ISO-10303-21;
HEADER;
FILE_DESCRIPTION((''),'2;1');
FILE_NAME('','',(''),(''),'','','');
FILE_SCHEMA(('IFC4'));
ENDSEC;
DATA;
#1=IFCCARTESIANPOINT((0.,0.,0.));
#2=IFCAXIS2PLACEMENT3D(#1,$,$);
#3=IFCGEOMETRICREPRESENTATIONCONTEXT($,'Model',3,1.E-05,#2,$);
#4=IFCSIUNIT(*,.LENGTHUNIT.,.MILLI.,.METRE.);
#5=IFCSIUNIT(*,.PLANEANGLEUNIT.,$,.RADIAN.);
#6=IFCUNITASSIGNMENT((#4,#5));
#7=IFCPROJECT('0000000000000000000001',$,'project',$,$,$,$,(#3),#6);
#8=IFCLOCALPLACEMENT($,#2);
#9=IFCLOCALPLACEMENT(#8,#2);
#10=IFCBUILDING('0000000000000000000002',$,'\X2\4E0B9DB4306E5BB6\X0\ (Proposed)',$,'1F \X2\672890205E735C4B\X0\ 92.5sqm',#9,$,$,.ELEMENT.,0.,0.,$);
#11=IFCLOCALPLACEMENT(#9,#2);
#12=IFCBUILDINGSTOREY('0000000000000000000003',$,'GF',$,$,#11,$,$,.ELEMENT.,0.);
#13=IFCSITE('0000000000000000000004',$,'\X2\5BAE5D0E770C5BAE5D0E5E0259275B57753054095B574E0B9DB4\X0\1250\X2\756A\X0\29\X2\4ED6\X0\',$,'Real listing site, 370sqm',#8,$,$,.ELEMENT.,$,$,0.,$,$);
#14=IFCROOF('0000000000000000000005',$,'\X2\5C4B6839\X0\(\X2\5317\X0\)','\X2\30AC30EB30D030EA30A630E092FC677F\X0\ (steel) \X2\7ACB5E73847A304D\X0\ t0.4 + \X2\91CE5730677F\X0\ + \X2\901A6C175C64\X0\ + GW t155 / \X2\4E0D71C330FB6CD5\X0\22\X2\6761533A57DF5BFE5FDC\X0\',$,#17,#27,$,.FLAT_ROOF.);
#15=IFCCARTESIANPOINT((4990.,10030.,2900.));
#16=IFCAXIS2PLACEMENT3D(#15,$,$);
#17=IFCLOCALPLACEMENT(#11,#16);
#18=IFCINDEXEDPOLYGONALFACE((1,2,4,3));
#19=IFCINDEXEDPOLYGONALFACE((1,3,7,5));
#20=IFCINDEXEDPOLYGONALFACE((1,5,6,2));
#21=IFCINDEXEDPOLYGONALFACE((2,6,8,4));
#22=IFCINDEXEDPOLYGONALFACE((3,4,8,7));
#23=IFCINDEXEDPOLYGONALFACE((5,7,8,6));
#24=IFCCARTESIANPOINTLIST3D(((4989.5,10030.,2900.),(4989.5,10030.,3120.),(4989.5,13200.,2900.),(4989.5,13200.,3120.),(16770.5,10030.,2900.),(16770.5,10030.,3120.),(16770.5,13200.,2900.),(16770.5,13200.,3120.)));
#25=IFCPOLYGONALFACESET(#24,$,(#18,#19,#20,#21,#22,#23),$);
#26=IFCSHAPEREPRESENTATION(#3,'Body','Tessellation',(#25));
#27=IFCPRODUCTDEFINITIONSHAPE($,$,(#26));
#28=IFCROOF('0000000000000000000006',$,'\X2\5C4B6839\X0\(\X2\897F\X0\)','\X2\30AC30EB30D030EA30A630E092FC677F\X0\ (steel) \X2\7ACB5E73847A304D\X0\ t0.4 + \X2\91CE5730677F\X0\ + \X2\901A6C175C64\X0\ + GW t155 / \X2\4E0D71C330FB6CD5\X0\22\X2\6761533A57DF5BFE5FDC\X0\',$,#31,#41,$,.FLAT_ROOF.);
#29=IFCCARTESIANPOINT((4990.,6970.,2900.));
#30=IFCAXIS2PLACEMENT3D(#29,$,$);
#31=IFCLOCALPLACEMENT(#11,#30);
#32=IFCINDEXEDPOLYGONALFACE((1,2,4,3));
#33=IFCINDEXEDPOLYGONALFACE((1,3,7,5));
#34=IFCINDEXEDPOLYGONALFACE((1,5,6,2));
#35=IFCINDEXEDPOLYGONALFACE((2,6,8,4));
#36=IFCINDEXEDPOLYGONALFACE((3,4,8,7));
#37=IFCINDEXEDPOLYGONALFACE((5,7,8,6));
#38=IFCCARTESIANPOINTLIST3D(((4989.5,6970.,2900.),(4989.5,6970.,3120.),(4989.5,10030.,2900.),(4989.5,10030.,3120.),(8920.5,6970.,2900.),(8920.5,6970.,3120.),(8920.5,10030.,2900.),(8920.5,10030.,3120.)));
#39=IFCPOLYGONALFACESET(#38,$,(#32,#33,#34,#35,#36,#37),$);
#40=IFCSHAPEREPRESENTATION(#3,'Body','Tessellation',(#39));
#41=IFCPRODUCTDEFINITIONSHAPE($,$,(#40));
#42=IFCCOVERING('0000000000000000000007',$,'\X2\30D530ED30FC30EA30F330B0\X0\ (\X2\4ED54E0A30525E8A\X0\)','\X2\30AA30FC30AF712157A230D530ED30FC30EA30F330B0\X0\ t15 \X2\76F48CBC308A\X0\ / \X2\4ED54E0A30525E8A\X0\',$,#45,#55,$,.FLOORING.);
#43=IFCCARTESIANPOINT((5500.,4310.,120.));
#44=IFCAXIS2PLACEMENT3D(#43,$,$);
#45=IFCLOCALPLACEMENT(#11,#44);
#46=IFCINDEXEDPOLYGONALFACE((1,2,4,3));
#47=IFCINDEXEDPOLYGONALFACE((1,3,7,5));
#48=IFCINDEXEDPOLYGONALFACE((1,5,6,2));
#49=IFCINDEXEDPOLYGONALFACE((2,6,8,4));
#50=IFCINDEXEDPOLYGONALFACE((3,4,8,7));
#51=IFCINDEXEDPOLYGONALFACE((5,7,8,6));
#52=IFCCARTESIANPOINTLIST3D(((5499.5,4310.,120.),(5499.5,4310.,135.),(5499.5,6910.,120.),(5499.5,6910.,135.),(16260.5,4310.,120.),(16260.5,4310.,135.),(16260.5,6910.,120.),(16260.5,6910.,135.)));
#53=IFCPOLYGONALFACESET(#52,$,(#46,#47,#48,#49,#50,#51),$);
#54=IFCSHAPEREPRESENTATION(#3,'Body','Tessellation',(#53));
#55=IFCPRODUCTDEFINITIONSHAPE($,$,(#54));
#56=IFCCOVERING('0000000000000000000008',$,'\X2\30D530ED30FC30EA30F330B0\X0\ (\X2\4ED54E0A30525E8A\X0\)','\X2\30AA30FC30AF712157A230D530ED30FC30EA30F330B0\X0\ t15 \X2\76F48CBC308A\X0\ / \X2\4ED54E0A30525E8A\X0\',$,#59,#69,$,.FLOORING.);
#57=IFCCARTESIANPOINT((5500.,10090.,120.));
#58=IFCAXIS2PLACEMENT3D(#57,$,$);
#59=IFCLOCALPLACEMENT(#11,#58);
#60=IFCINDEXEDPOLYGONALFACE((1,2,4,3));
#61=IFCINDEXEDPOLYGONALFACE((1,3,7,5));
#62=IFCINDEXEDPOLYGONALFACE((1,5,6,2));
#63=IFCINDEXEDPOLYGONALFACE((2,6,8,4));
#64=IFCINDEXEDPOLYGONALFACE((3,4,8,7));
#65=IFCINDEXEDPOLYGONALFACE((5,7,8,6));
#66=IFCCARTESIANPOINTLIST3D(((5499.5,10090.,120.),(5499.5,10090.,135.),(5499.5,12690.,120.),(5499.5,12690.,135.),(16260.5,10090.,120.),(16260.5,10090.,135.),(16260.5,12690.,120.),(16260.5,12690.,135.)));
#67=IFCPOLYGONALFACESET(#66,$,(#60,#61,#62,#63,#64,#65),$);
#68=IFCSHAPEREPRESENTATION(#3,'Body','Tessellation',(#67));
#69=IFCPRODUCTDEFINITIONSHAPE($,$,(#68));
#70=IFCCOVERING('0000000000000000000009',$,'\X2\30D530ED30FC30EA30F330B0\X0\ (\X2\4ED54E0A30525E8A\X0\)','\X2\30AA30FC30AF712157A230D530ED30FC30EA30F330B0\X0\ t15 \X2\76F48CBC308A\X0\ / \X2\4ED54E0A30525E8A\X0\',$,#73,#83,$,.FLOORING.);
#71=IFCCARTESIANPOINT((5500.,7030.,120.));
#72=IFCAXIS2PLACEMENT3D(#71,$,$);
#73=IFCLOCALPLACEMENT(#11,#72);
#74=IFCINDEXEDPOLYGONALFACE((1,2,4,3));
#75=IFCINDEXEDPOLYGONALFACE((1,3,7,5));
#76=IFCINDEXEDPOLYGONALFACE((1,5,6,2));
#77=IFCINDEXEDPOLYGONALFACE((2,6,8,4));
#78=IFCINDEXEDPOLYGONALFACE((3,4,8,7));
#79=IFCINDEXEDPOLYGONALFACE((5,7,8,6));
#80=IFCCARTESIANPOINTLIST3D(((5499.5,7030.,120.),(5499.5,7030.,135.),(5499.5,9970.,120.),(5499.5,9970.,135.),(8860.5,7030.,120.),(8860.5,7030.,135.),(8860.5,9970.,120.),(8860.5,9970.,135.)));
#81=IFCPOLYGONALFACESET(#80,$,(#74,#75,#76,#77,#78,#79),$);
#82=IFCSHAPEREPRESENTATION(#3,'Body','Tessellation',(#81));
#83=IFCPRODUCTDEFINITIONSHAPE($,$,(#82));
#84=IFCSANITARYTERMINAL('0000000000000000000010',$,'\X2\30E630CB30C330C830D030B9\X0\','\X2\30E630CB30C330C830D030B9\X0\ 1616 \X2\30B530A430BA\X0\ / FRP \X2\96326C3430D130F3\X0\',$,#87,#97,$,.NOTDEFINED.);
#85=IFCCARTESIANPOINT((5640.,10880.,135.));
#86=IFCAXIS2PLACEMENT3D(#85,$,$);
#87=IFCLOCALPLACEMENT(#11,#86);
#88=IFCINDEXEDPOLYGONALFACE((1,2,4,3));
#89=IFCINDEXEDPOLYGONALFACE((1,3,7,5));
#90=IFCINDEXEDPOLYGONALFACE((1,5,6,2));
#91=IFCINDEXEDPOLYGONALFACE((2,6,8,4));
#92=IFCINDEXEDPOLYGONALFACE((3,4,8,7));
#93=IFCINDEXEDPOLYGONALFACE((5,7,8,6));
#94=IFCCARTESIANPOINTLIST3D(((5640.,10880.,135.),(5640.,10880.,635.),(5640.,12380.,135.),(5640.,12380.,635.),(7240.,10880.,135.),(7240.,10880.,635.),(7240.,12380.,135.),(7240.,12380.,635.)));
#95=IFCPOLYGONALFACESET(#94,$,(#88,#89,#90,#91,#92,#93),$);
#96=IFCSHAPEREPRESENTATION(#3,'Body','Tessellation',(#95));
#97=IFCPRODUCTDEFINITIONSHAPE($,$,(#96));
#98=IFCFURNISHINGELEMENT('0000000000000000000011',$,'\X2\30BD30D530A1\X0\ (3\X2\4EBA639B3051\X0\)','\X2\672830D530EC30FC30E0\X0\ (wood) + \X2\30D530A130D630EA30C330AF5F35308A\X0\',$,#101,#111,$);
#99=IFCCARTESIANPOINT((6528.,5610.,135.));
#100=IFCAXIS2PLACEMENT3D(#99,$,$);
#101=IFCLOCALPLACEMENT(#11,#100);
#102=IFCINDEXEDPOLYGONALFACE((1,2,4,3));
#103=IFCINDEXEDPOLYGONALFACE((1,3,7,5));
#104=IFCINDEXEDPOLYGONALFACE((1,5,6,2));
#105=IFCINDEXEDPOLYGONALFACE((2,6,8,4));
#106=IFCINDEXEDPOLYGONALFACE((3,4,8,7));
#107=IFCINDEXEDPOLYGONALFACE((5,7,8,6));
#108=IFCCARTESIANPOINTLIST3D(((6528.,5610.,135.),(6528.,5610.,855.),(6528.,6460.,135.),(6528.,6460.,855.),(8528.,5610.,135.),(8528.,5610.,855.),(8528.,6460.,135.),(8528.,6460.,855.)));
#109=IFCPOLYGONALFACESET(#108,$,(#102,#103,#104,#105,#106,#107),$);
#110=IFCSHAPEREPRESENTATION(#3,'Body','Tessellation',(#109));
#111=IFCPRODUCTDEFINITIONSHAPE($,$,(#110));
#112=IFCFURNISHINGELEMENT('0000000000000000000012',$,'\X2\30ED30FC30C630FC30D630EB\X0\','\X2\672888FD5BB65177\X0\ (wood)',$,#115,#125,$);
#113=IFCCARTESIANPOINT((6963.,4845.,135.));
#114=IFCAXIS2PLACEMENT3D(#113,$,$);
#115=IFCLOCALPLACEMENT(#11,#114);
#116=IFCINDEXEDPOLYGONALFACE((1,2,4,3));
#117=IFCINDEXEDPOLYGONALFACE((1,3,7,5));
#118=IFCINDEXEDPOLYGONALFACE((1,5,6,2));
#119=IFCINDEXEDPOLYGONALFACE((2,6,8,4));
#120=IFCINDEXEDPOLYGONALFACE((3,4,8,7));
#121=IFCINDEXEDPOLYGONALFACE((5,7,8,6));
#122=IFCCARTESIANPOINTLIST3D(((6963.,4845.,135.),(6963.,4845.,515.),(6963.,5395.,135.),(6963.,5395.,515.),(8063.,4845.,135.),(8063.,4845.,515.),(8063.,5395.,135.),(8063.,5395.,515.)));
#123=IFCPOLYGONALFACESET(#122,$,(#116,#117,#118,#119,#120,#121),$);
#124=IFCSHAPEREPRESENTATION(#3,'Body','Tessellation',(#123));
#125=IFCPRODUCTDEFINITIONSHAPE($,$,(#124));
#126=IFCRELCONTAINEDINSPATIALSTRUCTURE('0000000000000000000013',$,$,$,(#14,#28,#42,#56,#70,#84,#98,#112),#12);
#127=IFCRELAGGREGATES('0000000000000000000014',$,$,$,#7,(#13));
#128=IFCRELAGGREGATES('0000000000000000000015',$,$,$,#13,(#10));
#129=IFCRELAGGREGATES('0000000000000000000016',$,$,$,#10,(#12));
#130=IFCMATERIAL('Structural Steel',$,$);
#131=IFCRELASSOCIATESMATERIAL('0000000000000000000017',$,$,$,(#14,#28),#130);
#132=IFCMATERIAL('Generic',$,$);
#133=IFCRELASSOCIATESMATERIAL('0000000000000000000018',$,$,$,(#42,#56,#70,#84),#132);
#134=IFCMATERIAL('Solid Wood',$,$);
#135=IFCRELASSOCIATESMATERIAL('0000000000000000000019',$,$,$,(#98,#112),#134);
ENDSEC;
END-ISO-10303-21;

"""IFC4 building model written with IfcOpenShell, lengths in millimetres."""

from ifc_helpers import new_model, si_unit, frame, frame_2d, origin, place, context, project, spatial, rectangle, extrude, material, element, save


model = new_model("IFC4")

# Units and contexts
model_context = context("Model", 3, precision=1e-05, world=origin())
ifc_project = project(units=[si_unit("LENGTHUNIT", "METRE", prefix="MILLI"), si_unit("PLANEANGLEUNIT", "RADIAN")], contexts=[model_context])

# Site, building, storey
site_placement = place(None, origin())
site = spatial("IfcSite", under=ifc_project, at=site_placement, Name="宮崎県宮崎市大字田吉字下鶴1250番29他", ObjectType="Real listing site, 370sqm", CompositionType="ELEMENT", RefElevation=0.0)
building_placement = place(site_placement, origin())
building = spatial("IfcBuilding", under=site, at=building_placement, Name="下鶴の家 (Proposed)", ObjectType="1F 木造平屋 92.5sqm", CompositionType="ELEMENT", ElevationOfRefHeight=0.0, ElevationOfTerrain=0.0)
storey_placement = place(building_placement, origin())
storey = spatial("IfcBuildingStorey", under=building, at=storey_placement, Name="GF", CompositionType="ELEMENT", Elevation=0.0)

# Shared definitions
ifc_material_1 = material(Name="Solid Wood")

# Roofs
ifc_material_2 = material(Name="Structural Steel")
roof_1_placement = place(storey_placement, frame((4990.0, 10030.0, 2900.0)))
element("IfcRoof", 1, at=roof_1_placement, inside=storey, material=ifc_material_2, Name="屋根(北)", Description="ガルバリウム鋼板 (steel) 立平葺き t0.4 + 野地板 + 通気層 + GW t155 / 不燃・法22条区域対応", PredefinedType="FLAT_ROOF", context=model_context, shape_type="SweptSolid", body=[
    extrude(rectangle(XDim=11781.0, YDim=3170.0, at=frame_2d((5890.0, 1585.0))), frame((4990.0, 10030.0, 2900.0)), (0.0, 0.0, 1.0), 220.0),
])
roof_2_placement = place(storey_placement, frame((4990.0, 6970.0, 2900.0)))
element("IfcRoof", 2, at=roof_2_placement, inside=storey, material=ifc_material_2, Name="屋根(西)", Description="ガルバリウム鋼板 (steel) 立平葺き t0.4 + 野地板 + 通気層 + GW t155 / 不燃・法22条区域対応", PredefinedType="FLAT_ROOF", context=model_context, shape_type="SweptSolid", body=[
    extrude(rectangle(XDim=3931.0, YDim=3060.0, at=frame_2d((1965.0, 1530.0))), frame((4990.0, 6970.0, 2900.0)), (0.0, 0.0, 1.0), 220.0),
])

# Coverings
ifc_material_3 = material(Name="Generic")
covering_1_placement = place(storey_placement, frame((5500.0, 4310.0, 120.0)))
element("IfcCovering", 3, at=covering_1_placement, inside=storey, material=ifc_material_3, Name="フローリング (仕上げ床)", Description="オーク無垢フローリング t15 直貼り / 仕上げ床", PredefinedType="FLOORING", context=model_context, shape_type="SweptSolid", body=[
    extrude(rectangle(XDim=10761.0, YDim=2600.0, at=frame_2d((5380.0, 1300.0))), frame((5500.0, 4310.0, 120.0)), (0.0, 0.0, 1.0), 15.0),
])
covering_2_placement = place(storey_placement, frame((5500.0, 10090.0, 120.0)))
element("IfcCovering", 4, at=covering_2_placement, inside=storey, material=ifc_material_3, Name="フローリング (仕上げ床)", Description="オーク無垢フローリング t15 直貼り / 仕上げ床", PredefinedType="FLOORING", context=model_context, shape_type="SweptSolid", body=[
    extrude(rectangle(XDim=10761.0, YDim=2600.0, at=frame_2d((5380.0, 1300.0))), frame((5500.0, 10090.0, 120.0)), (0.0, 0.0, 1.0), 15.0),
])
covering_3_placement = place(storey_placement, frame((5500.0, 7030.0, 120.0)))
element("IfcCovering", 5, at=covering_3_placement, inside=storey, material=ifc_material_3, Name="フローリング (仕上げ床)", Description="オーク無垢フローリング t15 直貼り / 仕上げ床", PredefinedType="FLOORING", context=model_context, shape_type="SweptSolid", body=[
    extrude(rectangle(XDim=3361.0, YDim=2940.0, at=frame_2d((1680.0, 1470.0))), frame((5500.0, 7030.0, 120.0)), (0.0, 0.0, 1.0), 15.0),
])

# Sanitary terminal
sanitary_terminal_placement = place(storey_placement, frame((5640.0, 10880.0, 135.0)))
element("IfcSanitaryTerminal", 6, at=sanitary_terminal_placement, inside=storey, material=ifc_material_3, Name="ユニットバス", Description="ユニットバス 1616 サイズ / FRP 防水パン", PredefinedType="NOTDEFINED", context=model_context, shape_type="SweptSolid", body=[
    extrude(rectangle(XDim=1600.0, YDim=1500.0, at=frame_2d((800.0, 750.0))), frame((5640.0, 10880.0, 135.0)), (0.0, 0.0, 1.0), 500.0),
])

# Furnishing elements
furnishing_1_placement = place(storey_placement, frame((6528.0, 5610.0, 135.0)))
element("IfcFurnishingElement", 7, at=furnishing_1_placement, inside=storey, material=ifc_material_1, Name="ソファ (3人掛け)", Description="木フレーム (wood) + ファブリック張り", context=model_context, shape_type="SweptSolid", body=[
    extrude(rectangle(XDim=2000.0, YDim=850.0, at=frame_2d((1000.0, 425.0))), frame((6528.0, 5610.0, 135.0)), (0.0, 0.0, 1.0), 720.0),
])
furnishing_2_placement = place(storey_placement, frame((6963.0, 4845.0, 135.0)))
element("IfcFurnishingElement", 8, at=furnishing_2_placement, inside=storey, material=ifc_material_1, Name="ローテーブル", Description="木製家具 (wood)", context=model_context, shape_type="SweptSolid", body=[
    extrude(rectangle(XDim=1100.0, YDim=550.0, at=frame_2d((550.0, 275.0))), frame((6963.0, 4845.0, 135.0)), (0.0, 0.0, 1.0), 380.0),
])

save(model, "model.ifc")
